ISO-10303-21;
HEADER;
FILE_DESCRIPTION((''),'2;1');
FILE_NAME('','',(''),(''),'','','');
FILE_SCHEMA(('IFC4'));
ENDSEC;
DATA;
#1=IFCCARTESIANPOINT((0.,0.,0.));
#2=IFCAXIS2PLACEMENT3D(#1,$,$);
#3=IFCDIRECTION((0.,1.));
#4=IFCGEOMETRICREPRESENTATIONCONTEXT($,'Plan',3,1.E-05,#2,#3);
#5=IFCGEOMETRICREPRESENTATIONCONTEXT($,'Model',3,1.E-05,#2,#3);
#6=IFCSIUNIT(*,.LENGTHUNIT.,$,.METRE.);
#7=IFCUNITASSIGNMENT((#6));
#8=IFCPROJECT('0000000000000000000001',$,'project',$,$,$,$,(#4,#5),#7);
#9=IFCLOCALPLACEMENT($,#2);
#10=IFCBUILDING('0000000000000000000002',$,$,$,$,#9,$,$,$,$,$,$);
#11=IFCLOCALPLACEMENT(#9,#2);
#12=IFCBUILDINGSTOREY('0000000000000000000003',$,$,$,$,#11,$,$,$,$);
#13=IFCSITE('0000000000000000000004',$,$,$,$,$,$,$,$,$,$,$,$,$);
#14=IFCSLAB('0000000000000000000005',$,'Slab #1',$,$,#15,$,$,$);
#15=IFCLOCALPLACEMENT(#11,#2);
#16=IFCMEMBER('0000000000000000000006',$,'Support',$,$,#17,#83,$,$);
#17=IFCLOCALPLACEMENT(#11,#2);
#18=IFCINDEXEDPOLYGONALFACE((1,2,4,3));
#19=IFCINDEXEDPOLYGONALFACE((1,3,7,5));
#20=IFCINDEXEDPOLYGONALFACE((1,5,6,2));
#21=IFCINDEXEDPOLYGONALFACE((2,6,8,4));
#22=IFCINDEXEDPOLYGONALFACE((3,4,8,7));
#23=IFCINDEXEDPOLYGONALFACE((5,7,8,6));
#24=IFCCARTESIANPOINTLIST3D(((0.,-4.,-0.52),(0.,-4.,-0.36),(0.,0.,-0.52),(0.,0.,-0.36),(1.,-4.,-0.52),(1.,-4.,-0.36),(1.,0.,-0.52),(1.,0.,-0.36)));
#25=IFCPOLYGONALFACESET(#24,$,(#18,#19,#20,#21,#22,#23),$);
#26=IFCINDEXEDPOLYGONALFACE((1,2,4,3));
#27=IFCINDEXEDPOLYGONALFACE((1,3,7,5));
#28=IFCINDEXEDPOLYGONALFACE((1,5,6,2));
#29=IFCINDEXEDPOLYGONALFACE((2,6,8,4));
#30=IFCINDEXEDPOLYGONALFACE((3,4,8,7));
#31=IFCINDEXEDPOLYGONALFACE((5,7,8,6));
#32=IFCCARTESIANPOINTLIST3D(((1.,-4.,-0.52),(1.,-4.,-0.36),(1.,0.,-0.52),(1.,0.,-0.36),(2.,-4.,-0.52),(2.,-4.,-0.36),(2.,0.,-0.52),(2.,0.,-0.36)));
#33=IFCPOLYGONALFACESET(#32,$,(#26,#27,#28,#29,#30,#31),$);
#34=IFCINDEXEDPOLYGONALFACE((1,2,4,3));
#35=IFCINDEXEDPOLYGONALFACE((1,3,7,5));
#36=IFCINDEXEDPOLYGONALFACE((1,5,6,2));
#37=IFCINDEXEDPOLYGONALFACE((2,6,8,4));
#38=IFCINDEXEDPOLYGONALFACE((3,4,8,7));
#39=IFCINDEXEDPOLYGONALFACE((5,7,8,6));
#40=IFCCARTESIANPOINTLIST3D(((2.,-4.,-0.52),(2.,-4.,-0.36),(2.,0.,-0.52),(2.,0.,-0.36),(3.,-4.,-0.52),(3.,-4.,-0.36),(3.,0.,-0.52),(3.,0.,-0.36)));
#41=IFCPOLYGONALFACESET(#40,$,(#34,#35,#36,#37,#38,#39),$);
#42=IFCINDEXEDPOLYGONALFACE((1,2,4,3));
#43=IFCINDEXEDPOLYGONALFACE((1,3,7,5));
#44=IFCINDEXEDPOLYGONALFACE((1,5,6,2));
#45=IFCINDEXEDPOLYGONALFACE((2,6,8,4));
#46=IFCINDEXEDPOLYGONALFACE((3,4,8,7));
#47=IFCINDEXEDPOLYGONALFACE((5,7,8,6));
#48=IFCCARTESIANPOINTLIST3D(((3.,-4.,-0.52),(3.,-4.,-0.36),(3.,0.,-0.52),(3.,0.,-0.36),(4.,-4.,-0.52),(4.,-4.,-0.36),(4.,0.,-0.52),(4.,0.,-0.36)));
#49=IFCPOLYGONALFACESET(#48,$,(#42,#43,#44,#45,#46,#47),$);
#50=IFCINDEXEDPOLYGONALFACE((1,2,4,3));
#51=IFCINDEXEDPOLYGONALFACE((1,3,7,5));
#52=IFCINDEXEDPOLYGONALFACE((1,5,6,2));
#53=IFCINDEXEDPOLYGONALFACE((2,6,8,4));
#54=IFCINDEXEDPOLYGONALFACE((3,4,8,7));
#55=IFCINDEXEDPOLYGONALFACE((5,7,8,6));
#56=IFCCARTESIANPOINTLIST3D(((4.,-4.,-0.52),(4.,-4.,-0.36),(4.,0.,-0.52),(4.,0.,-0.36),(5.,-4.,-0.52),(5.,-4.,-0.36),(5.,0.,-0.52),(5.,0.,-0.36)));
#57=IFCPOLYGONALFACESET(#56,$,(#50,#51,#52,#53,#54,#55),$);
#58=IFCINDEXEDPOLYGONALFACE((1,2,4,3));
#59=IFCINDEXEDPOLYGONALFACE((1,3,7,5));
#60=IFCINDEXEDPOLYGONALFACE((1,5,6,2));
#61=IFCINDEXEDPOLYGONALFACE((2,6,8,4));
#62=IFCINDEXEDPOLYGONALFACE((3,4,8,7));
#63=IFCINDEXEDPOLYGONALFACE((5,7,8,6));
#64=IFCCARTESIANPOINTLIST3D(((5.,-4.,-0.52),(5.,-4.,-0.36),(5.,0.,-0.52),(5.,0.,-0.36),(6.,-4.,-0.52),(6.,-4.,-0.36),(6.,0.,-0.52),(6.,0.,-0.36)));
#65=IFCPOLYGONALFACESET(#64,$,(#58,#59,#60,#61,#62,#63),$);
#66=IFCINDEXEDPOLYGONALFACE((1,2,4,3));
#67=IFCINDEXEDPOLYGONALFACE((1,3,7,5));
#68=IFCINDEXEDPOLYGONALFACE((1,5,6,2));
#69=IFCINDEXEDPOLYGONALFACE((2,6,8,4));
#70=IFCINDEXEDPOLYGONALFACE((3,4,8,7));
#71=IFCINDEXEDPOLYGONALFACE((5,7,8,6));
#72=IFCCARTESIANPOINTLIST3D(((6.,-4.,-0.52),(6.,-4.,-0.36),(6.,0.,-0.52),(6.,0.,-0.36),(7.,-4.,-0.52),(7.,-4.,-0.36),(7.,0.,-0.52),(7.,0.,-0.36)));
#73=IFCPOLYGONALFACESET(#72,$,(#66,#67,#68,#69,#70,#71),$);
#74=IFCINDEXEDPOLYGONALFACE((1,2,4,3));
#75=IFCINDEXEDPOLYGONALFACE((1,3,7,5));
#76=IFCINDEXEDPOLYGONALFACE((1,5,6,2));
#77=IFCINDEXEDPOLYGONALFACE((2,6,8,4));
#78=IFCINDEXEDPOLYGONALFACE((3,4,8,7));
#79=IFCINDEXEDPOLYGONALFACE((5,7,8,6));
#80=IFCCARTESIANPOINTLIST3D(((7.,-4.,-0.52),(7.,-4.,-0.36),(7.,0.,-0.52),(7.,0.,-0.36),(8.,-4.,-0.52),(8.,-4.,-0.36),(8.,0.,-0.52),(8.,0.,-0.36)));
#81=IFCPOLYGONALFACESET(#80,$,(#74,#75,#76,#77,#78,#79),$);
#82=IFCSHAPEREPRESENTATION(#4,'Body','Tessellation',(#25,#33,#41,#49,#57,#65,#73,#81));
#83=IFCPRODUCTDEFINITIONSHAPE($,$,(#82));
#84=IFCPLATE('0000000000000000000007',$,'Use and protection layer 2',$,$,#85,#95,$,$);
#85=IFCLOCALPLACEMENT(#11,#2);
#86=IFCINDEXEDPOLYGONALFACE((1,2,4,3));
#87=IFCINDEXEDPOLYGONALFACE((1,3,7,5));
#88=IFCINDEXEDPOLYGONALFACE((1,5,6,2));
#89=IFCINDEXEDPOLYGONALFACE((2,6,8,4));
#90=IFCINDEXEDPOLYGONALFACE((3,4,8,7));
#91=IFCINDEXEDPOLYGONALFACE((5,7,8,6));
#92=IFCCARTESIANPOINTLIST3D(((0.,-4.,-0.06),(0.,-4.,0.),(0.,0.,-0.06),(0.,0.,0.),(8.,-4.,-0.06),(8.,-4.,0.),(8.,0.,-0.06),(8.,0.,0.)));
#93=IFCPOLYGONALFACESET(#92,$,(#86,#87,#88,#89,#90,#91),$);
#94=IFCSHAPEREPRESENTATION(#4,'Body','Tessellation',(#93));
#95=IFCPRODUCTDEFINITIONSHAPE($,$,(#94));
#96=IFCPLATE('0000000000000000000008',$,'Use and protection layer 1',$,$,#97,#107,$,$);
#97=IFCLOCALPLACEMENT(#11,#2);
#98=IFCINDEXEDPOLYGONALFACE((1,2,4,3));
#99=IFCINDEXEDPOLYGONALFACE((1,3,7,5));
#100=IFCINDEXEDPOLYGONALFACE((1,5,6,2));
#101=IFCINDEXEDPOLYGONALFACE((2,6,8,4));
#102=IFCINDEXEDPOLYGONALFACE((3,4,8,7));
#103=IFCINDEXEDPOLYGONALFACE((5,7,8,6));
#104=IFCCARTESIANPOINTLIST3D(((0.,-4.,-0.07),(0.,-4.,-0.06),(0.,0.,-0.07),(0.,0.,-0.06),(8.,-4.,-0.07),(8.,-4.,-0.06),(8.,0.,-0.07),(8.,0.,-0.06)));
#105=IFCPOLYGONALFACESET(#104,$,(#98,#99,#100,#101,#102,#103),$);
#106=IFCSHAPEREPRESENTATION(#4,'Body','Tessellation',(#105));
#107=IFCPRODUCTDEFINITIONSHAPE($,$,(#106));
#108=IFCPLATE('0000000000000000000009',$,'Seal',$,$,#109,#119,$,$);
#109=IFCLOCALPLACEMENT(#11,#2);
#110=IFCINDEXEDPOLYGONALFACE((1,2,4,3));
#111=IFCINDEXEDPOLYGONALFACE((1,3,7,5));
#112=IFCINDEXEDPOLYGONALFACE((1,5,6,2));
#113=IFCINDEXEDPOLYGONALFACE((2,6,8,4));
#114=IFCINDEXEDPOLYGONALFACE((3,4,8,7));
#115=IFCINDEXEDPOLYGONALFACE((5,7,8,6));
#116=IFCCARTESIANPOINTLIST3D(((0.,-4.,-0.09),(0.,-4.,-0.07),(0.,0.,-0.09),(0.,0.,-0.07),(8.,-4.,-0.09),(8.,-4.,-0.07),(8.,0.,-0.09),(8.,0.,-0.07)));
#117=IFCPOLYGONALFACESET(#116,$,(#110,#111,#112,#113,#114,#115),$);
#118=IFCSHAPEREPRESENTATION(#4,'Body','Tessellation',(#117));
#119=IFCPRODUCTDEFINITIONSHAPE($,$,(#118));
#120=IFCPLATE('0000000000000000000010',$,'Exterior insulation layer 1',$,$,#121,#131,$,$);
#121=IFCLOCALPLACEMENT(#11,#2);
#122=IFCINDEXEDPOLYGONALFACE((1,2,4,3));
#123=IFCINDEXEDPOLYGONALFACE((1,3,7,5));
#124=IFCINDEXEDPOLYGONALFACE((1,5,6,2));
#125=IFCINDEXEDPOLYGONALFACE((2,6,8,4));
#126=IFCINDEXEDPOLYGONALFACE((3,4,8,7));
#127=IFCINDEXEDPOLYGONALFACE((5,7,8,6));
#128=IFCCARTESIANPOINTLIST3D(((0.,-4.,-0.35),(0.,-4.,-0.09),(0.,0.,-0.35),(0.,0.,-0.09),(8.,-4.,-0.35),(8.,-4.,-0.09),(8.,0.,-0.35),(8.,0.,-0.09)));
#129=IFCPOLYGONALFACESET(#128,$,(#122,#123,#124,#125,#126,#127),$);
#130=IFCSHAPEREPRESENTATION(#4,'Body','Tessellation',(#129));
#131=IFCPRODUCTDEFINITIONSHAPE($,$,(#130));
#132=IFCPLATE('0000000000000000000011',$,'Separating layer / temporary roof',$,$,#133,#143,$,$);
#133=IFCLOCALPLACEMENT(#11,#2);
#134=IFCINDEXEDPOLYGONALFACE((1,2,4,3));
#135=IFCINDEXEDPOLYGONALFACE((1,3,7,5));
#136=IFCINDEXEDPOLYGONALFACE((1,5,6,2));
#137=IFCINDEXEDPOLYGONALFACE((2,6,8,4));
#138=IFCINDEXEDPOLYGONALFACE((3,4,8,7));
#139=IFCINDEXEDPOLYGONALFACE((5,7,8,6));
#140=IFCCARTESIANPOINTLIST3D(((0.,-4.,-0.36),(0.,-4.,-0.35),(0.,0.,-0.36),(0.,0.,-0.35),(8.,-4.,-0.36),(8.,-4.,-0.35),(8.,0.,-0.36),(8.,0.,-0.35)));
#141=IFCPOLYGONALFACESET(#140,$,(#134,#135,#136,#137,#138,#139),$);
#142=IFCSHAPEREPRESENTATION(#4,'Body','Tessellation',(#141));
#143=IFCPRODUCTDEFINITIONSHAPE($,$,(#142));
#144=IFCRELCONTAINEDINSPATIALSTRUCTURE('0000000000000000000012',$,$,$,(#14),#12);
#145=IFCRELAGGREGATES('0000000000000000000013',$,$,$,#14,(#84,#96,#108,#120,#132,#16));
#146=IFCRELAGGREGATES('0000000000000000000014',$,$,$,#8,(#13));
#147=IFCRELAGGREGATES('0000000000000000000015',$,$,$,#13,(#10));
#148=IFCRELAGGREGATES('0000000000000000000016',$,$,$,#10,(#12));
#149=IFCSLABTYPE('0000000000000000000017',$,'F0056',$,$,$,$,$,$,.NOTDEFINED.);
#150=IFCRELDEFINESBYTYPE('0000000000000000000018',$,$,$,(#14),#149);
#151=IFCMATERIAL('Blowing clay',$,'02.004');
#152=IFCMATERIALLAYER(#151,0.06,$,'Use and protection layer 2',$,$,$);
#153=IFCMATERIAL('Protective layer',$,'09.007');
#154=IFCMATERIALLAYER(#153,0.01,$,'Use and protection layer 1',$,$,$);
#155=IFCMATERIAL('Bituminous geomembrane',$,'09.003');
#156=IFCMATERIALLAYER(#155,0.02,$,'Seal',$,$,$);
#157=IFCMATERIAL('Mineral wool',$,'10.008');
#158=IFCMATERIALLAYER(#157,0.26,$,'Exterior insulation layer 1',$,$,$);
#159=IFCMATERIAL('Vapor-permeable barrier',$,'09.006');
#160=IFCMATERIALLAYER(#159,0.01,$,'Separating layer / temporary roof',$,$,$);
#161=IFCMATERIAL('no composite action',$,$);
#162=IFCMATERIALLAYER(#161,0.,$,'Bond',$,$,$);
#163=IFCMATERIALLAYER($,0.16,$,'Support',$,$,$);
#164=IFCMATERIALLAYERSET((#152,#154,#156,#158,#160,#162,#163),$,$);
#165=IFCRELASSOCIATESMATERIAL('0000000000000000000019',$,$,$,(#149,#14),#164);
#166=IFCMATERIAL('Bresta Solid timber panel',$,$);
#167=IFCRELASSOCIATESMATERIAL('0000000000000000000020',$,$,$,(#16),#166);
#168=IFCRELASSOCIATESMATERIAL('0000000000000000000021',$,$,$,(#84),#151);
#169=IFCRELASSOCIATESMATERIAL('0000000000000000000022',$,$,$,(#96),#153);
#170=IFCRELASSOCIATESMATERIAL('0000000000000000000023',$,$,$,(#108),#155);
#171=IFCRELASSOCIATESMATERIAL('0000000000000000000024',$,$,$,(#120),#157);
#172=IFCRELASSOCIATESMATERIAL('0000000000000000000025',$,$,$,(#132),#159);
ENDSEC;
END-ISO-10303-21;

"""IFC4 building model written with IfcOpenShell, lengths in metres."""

from ifc_helpers import new_model, si_unit, direction, frame, frame_2d, origin, origin_with_axes, place, context, project, spatial, rectangle, extrude, material, layer, layer_set, type_object, element, aggregate, save


model = new_model("IFC4")

# Units and contexts
plan_context = context("Plan", 3, precision=1e-05, world=origin(), true_north=direction((0.0, 1.0)))
model_context = context("Model", 3, precision=1e-05, world=origin(), true_north=direction((0.0, 1.0)))
ifc_project = project(units=[si_unit("LENGTHUNIT", "METRE")], contexts=[plan_context, model_context])

# Site, building, storey
site = spatial("IfcSite", under=ifc_project)
building_placement = place(None, origin())
building = spatial("IfcBuilding", under=site, at=building_placement)
storey_placement = place(building_placement, origin())
storey = spatial("IfcBuildingStorey", under=building, at=storey_placement)

# Slab, member, plates
ifc_material_1 = material(Name="Blowing clay", Category="02.004")
ifc_layer_1 = layer(ifc_material_1, 0.06, Name="Use and protection layer 2")
ifc_material_2 = material(Name="Protective layer", Category="09.007")
ifc_layer_2 = layer(ifc_material_2, 0.01, Name="Use and protection layer 1")
ifc_material_3 = material(Name="Bituminous geomembrane", Category="09.003")
ifc_layer_3 = layer(ifc_material_3, 0.02, Name="Seal")
ifc_material_4 = material(Name="Mineral wool", Category="10.008")
ifc_layer_4 = layer(ifc_material_4, 0.26, Name="Exterior insulation layer 1")
ifc_material_5 = material(Name="Vapor-permeable barrier", Category="09.006")
ifc_layer_5 = layer(ifc_material_5, 0.01, Name="Separating layer / temporary roof")
ifc_material_6 = material(Name="no composite action")
ifc_layer_6 = layer(ifc_material_6, 0.0, Name="Bond")
ifc_layer_7 = layer(None, 0.16, Name="Support")
ifc_layer_set = layer_set([ifc_layer_1, ifc_layer_2, ifc_layer_3, ifc_layer_4, ifc_layer_5, ifc_layer_6, ifc_layer_7])
slab_type = type_object("IfcSlabType", Name="F0056", PredefinedType="NOTDEFINED", material=ifc_layer_set)
slab_placement = place(None, frame((0.0, 0.0, 0.0), z_axis=(0.0, 0.0, -1.0), x_axis=(1.0, 0.0, 0.0)))
slab = element("IfcSlab", 1, at=slab_placement, inside=storey, type_object=slab_type, material=ifc_layer_set, Name="Slab #1")
ifc_material_7 = material(Name="Bresta Solid timber panel")
member_placement = place(slab_placement, origin())
member = element("IfcMember", 2, at=member_placement, material=ifc_material_7, Name="Support", context=plan_context, shape_type="SweptSolid", body=[
    extrude(rectangle(XDim=1.0, YDim=0.16, at=frame_2d((0.5, 0.08), x_axis=(1.0, 0.0))), frame((0.0, 4.0, 0.36), z_axis=(0.0, -1.0, 0.0), x_axis=(1.0, 0.0, 0.0)), (0.0, 0.0, 1.0), 4.0),
    extrude(rectangle(XDim=1.0, YDim=0.16, at=frame_2d((0.5, 0.08), x_axis=(1.0, 0.0))), frame((1.0, 4.0, 0.36), z_axis=(0.0, -1.0, 0.0), x_axis=(1.0, 0.0, 0.0)), (0.0, 0.0, 1.0), 4.0),
    extrude(rectangle(XDim=1.0, YDim=0.16, at=frame_2d((0.5, 0.08), x_axis=(1.0, 0.0))), frame((2.0, 4.0, 0.36), z_axis=(0.0, -1.0, 0.0), x_axis=(1.0, 0.0, 0.0)), (0.0, 0.0, 1.0), 4.0),
    extrude(rectangle(XDim=1.0, YDim=0.16, at=frame_2d((0.5, 0.08), x_axis=(1.0, 0.0))), frame((3.0, 4.0, 0.36), z_axis=(0.0, -1.0, 0.0), x_axis=(1.0, 0.0, 0.0)), (0.0, 0.0, 1.0), 4.0),
    extrude(rectangle(XDim=1.0, YDim=0.16, at=frame_2d((0.5, 0.08), x_axis=(1.0, 0.0))), frame((4.0, 4.0, 0.36), z_axis=(0.0, -1.0, 0.0), x_axis=(1.0, 0.0, 0.0)), (0.0, 0.0, 1.0), 4.0),
    extrude(rectangle(XDim=1.0, YDim=0.16, at=frame_2d((0.5, 0.08), x_axis=(1.0, 0.0))), frame((5.0, 4.0, 0.36), z_axis=(0.0, -1.0, 0.0), x_axis=(1.0, 0.0, 0.0)), (0.0, 0.0, 1.0), 4.0),
    extrude(rectangle(XDim=1.0, YDim=0.16, at=frame_2d((0.5, 0.08), x_axis=(1.0, 0.0))), frame((6.0, 4.0, 0.36), z_axis=(0.0, -1.0, 0.0), x_axis=(1.0, 0.0, 0.0)), (0.0, 0.0, 1.0), 4.0),
    extrude(rectangle(XDim=1.0, YDim=0.16, at=frame_2d((0.5, 0.08), x_axis=(1.0, 0.0))), frame((7.0, 4.0, 0.36), z_axis=(0.0, -1.0, 0.0), x_axis=(1.0, 0.0, 0.0)), (0.0, 0.0, 1.0), 4.0),
])
plate_1_placement = place(slab_placement, origin())
plate_1 = element("IfcPlate", 3, at=plate_1_placement, material=ifc_material_1, Name="Use and protection layer 2", context=plan_context, shape_type="SweptSolid", body=[
    extrude(rectangle(XDim=8.0, YDim=4.0, at=frame_2d((4.0, 2.0), x_axis=(1.0, 0.0))), origin_with_axes(), (0.0, 0.0, 1.0), 0.06),
])
plate_2_placement = place(slab_placement, origin())
plate_2 = element("IfcPlate", 4, at=plate_2_placement, material=ifc_material_2, Name="Use and protection layer 1", context=plan_context, shape_type="SweptSolid", body=[
    extrude(rectangle(XDim=8.0, YDim=4.0, at=frame_2d((4.0, 2.0), x_axis=(1.0, 0.0))), frame((0.0, 0.0, 0.06), z_axis=(0.0, 0.0, 1.0), x_axis=(1.0, 0.0, 0.0)), (0.0, 0.0, 1.0), 0.01),
])
plate_3_placement = place(slab_placement, origin())
plate_3 = element("IfcPlate", 5, at=plate_3_placement, material=ifc_material_3, Name="Seal", context=plan_context, shape_type="SweptSolid", body=[
    extrude(rectangle(XDim=8.0, YDim=4.0, at=frame_2d((4.0, 2.0), x_axis=(1.0, 0.0))), frame((0.0, 0.0, 0.07), z_axis=(0.0, 0.0, 1.0), x_axis=(1.0, 0.0, 0.0)), (0.0, 0.0, 1.0), 0.02),
])
plate_4_placement = place(slab_placement, origin())
plate_4 = element("IfcPlate", 6, at=plate_4_placement, material=ifc_material_4, Name="Exterior insulation layer 1", context=plan_context, shape_type="SweptSolid", body=[
    extrude(rectangle(XDim=8.0, YDim=4.0, at=frame_2d((4.0, 2.0), x_axis=(1.0, 0.0))), frame((0.0, 0.0, 0.09), z_axis=(0.0, 0.0, 1.0), x_axis=(1.0, 0.0, 0.0)), (0.0, 0.0, 1.0), 0.26),
])
plate_5_placement = place(slab_placement, origin())
plate_5 = element("IfcPlate", 7, at=plate_5_placement, material=ifc_material_5, Name="Separating layer / temporary roof", context=plan_context, shape_type="SweptSolid", body=[
    extrude(rectangle(XDim=8.0, YDim=4.0, at=frame_2d((4.0, 2.0), x_axis=(1.0, 0.0))), frame((0.0, 0.0, 0.35), z_axis=(0.0, 0.0, 1.0), x_axis=(1.0, 0.0, 0.0)), (0.0, 0.0, 1.0), 0.01),
])
aggregate(slab, [plate_1, plate_2, plate_3, plate_4, plate_5, member])

save(model, "model.ifc")
